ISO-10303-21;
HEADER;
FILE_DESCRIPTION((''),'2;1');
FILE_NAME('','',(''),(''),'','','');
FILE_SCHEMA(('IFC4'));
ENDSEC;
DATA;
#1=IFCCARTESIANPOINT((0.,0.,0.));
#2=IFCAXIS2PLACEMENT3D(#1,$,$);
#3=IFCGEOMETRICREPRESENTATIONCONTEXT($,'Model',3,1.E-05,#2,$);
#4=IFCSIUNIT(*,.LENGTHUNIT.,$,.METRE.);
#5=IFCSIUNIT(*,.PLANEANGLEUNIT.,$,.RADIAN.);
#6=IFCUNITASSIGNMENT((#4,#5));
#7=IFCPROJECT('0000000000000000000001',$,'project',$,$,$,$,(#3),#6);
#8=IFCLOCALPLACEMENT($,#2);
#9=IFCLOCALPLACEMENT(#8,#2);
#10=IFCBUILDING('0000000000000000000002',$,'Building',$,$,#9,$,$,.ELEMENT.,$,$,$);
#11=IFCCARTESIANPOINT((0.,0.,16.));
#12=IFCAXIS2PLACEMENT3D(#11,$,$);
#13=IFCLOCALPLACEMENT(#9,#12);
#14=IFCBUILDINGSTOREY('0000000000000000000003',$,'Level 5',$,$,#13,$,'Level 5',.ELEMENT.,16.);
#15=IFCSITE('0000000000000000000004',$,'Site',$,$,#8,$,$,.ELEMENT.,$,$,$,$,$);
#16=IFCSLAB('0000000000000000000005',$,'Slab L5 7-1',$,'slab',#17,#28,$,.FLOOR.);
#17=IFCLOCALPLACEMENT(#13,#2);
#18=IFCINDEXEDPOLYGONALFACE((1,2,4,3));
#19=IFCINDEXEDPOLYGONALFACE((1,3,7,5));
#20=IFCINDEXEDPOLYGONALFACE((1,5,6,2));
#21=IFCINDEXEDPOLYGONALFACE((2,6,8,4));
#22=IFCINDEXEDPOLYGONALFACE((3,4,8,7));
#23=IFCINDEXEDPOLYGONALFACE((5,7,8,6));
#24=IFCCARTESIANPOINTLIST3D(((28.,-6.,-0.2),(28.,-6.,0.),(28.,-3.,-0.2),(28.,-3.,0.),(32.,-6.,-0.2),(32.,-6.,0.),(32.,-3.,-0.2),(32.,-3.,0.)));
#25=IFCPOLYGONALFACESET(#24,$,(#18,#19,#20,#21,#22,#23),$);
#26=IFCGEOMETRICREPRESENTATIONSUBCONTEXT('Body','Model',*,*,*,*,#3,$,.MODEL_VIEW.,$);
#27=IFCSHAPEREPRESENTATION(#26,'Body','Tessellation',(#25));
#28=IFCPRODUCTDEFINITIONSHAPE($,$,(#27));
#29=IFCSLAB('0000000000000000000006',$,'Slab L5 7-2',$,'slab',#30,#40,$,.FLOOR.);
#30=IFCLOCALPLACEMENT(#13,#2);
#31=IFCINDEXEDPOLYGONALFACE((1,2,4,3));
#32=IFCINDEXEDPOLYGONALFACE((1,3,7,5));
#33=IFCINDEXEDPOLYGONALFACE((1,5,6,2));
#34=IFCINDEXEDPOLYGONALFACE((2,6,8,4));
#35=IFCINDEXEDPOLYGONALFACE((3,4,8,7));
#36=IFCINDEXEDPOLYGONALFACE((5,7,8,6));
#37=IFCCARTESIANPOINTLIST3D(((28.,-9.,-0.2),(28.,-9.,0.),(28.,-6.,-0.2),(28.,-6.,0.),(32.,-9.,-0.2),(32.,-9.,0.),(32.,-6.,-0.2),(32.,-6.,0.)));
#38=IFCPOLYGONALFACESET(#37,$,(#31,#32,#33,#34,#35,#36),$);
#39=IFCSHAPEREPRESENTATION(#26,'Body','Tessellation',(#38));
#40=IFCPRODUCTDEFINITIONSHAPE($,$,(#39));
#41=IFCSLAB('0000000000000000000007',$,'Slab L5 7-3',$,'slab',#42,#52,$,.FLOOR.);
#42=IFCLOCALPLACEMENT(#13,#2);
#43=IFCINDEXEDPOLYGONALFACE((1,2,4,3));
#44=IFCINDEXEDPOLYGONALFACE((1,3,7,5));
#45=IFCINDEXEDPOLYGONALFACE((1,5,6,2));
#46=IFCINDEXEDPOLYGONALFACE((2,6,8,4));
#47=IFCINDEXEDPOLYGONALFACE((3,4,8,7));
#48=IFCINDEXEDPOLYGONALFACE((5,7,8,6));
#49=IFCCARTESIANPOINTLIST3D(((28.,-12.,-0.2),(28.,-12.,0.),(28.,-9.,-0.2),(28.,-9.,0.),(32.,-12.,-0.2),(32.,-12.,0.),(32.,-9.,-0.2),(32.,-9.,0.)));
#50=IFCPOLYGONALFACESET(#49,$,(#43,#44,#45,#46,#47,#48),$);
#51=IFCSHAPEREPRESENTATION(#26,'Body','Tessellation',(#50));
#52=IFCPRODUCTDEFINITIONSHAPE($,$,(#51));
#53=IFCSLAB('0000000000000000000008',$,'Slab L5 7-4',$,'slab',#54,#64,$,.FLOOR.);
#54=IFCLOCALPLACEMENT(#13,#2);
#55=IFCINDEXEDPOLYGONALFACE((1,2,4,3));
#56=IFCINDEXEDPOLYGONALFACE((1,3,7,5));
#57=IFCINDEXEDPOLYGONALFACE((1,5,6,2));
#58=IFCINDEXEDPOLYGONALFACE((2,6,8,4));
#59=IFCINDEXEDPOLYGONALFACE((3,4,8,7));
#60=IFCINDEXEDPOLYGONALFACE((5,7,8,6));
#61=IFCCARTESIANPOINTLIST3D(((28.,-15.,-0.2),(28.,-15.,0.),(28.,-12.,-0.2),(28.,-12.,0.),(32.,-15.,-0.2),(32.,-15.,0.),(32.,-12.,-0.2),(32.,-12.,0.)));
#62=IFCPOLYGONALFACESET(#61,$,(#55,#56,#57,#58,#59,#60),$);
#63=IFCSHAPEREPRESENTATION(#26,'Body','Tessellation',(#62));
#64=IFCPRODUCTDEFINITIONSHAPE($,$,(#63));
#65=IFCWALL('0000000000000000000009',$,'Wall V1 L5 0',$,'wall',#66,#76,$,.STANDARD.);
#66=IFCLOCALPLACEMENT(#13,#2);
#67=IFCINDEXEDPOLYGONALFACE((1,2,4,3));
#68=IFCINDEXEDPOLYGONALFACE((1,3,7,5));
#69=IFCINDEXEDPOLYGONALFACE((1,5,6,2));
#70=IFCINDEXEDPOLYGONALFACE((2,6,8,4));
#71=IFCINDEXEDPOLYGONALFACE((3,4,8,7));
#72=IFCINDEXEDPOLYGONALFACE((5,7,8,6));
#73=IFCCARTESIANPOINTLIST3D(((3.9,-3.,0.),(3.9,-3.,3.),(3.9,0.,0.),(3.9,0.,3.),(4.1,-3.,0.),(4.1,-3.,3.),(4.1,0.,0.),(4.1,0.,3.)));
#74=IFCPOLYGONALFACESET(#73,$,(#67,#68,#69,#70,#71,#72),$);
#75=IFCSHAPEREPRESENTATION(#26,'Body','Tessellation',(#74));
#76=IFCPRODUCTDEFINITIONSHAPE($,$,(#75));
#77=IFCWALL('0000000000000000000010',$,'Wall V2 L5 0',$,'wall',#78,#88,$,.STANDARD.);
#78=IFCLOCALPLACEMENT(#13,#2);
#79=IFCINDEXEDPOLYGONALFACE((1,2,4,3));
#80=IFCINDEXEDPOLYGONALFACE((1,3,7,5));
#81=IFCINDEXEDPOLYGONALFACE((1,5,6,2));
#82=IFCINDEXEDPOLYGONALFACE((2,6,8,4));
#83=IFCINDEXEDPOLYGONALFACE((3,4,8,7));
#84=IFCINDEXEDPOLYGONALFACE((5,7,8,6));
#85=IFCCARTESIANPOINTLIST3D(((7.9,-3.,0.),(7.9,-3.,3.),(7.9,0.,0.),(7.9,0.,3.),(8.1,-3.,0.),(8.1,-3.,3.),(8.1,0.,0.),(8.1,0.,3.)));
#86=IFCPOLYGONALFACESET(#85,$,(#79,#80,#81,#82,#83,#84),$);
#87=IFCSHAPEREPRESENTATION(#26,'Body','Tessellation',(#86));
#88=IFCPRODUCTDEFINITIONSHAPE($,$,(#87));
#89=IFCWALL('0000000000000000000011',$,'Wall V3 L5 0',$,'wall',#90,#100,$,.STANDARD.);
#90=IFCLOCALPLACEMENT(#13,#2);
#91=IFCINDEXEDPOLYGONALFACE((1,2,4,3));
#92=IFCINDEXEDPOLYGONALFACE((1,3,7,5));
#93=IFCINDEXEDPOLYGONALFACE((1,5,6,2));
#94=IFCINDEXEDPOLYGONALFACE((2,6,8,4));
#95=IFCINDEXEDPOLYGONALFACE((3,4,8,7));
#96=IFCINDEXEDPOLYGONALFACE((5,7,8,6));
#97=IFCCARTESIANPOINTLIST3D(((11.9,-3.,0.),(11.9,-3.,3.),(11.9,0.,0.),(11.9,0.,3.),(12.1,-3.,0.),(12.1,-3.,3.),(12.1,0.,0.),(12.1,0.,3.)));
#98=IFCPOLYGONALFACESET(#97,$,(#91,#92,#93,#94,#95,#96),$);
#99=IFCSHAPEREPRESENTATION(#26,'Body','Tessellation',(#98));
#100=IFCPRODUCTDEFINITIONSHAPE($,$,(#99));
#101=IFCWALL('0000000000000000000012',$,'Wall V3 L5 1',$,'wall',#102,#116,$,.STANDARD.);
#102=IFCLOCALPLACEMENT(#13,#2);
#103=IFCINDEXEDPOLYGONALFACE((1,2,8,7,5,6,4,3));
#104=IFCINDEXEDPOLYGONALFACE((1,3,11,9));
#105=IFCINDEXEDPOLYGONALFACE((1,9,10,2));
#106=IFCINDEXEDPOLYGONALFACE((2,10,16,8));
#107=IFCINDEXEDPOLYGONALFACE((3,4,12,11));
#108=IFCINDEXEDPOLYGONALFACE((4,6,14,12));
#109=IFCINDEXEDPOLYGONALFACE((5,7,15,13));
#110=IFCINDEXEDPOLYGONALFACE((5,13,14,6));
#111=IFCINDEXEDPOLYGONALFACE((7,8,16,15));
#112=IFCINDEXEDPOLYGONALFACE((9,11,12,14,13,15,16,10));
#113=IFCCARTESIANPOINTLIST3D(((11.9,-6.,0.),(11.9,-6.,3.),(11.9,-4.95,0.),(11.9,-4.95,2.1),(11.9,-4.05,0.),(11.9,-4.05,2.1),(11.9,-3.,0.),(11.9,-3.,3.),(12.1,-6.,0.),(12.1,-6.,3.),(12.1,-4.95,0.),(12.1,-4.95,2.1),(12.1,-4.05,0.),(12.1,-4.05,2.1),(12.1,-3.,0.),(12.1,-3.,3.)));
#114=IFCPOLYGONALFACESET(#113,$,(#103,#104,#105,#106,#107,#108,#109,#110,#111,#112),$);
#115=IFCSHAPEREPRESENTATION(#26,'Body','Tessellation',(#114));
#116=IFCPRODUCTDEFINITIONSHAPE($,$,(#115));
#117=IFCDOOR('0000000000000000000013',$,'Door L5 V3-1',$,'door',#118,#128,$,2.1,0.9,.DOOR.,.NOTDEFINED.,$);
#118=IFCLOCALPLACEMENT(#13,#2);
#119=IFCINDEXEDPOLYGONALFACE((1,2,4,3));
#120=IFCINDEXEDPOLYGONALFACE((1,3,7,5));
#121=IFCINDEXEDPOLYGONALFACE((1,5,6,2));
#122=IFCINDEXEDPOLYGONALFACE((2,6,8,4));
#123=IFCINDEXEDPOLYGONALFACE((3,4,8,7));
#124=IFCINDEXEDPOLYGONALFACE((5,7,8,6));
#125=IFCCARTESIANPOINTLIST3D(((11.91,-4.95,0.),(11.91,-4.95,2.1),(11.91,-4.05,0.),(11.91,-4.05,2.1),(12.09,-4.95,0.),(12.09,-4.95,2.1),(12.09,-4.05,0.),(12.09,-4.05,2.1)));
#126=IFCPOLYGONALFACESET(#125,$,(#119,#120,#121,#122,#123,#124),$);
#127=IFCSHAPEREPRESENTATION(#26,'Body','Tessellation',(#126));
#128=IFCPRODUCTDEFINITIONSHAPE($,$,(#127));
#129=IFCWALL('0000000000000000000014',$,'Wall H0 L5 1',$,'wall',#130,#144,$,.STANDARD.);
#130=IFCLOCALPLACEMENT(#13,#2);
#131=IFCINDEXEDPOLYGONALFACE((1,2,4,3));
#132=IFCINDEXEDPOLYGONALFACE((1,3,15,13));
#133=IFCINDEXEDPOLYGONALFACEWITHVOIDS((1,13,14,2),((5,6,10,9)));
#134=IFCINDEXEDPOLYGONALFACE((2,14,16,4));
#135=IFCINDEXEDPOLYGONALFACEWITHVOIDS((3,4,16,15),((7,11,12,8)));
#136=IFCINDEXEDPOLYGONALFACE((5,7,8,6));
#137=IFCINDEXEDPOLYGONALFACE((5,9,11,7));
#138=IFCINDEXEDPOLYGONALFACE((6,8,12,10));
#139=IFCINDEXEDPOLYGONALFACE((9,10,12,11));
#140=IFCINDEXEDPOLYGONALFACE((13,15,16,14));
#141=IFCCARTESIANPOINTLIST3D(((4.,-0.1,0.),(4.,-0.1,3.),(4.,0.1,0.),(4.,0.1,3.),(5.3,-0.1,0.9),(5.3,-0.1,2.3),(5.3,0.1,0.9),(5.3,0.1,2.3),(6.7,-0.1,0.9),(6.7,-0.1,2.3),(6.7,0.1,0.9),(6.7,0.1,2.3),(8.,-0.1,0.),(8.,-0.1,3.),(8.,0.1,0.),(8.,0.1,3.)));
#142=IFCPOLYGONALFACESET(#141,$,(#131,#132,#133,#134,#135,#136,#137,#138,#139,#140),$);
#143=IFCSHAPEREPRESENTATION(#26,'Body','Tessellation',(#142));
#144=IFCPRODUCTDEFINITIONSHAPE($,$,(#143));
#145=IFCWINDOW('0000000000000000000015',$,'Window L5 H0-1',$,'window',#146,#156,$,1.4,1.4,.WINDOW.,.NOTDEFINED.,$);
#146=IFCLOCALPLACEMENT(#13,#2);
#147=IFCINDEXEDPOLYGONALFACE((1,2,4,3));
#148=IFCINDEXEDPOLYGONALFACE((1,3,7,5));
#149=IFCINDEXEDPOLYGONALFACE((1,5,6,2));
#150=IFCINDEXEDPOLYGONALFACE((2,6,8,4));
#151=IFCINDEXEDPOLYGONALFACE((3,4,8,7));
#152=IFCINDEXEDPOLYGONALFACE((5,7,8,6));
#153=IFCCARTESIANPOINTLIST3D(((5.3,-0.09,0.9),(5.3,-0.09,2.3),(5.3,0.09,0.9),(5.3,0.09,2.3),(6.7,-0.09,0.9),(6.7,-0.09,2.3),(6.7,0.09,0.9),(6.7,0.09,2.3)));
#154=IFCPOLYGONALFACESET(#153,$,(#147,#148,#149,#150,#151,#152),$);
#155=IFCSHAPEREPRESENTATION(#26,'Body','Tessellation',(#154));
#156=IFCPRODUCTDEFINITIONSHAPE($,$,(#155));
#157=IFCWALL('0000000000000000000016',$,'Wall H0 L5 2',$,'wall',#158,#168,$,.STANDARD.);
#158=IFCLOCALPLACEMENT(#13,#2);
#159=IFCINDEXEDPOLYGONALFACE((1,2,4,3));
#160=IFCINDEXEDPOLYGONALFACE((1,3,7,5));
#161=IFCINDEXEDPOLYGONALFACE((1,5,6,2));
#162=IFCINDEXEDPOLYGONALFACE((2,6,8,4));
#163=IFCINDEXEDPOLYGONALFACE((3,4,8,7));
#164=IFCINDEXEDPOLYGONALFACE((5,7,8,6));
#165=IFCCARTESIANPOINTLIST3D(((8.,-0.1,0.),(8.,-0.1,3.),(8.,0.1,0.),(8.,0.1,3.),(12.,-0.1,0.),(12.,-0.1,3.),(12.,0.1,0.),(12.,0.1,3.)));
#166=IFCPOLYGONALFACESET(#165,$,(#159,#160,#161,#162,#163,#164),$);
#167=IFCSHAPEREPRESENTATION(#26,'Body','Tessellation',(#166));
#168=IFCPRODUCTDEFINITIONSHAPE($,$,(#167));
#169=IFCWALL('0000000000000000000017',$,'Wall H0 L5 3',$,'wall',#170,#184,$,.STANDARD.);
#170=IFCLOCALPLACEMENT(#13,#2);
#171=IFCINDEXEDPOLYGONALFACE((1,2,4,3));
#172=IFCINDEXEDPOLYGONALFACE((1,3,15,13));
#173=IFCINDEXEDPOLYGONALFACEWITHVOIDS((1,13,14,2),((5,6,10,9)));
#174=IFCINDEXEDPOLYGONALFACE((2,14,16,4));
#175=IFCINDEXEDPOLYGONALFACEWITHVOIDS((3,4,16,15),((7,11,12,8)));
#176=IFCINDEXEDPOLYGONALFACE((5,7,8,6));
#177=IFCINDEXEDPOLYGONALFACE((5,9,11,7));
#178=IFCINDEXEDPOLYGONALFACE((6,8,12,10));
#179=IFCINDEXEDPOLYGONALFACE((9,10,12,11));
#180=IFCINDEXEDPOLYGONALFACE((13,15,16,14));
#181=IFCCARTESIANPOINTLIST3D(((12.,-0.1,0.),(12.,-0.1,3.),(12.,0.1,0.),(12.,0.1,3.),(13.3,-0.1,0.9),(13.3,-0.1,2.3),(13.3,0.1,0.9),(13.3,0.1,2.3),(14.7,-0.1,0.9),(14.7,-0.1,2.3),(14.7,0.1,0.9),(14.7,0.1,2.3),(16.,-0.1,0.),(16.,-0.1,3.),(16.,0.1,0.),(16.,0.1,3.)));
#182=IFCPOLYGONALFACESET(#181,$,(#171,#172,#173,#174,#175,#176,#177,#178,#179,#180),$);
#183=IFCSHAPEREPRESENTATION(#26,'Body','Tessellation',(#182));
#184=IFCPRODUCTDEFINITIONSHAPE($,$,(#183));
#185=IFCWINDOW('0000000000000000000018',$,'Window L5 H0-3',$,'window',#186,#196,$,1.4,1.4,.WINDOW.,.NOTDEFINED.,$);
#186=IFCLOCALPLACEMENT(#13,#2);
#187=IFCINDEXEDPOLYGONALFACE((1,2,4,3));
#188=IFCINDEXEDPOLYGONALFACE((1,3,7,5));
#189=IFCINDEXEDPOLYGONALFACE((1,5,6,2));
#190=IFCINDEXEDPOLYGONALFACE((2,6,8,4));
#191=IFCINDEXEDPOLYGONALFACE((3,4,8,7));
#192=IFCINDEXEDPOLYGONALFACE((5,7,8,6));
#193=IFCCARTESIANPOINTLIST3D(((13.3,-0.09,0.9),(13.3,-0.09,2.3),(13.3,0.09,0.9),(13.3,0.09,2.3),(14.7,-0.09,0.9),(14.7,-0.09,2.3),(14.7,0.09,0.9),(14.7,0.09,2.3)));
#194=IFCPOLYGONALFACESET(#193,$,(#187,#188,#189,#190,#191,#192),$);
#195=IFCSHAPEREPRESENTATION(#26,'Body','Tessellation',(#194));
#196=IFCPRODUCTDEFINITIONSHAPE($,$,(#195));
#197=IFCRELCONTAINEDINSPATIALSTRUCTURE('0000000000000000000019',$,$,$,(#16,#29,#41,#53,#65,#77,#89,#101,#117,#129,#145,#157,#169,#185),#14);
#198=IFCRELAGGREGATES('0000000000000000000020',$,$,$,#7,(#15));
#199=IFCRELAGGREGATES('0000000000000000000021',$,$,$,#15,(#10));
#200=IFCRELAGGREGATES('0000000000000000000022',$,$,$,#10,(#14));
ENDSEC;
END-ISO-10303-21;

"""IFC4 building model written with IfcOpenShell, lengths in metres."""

from ifc_helpers import new_model, si_unit, frame, frame_2d, origin, origin_2d, place, context, subcontext, project, spatial, polyline, rectangle, outline, extrude, element, fill, save


model = new_model("IFC4")

# Units and contexts
model_context = context("Model", 3, precision=1e-05, world=origin())
body_context = subcontext(model_context, "Body", "Model", "MODEL_VIEW")
ifc_project = project(units=[si_unit("LENGTHUNIT", "METRE"), si_unit("PLANEANGLEUNIT", "RADIAN")], contexts=[model_context])

# Site, building, storey
site_placement = place(None, origin())
site = spatial("IfcSite", under=ifc_project, at=site_placement, Name="Site", CompositionType="ELEMENT")
building_placement = place(site_placement, origin())
building = spatial("IfcBuilding", under=site, at=building_placement, Name="Building", CompositionType="ELEMENT")
storey_placement = place(building_placement, frame((0.0, 0.0, 16.0)))
storey = spatial("IfcBuildingStorey", under=building, at=storey_placement, Name="Level 5", LongName="Level 5", CompositionType="ELEMENT", Elevation=16.0)

# Slabs
slab_1_placement = place(storey_placement, frame((0.0, 0.0, -0.2)))
element("IfcSlab", 1, at=slab_1_placement, inside=storey, Name="Slab L5 7-1", ObjectType="slab", PredefinedType="FLOOR", context=body_context, shape_type="SweptSolid", body=[
    extrude(outline(polyline([(28.0, -6.0), (32.0, -6.0), (32.0, -3.0), (28.0, -3.0), (28.0, -6.0)])), origin(), (0.0, 0.0, 1.0), 0.2),
])
slab_2_placement = place(storey_placement, frame((0.0, 0.0, -0.2)))
element("IfcSlab", 2, at=slab_2_placement, inside=storey, Name="Slab L5 7-2", ObjectType="slab", PredefinedType="FLOOR", context=body_context, shape_type="SweptSolid", body=[
    extrude(outline(polyline([(28.0, -9.0), (32.0, -9.0), (32.0, -6.0), (28.0, -6.0), (28.0, -9.0)])), origin(), (0.0, 0.0, 1.0), 0.2),
])
slab_3_placement = place(storey_placement, frame((0.0, 0.0, -0.2)))
element("IfcSlab", 3, at=slab_3_placement, inside=storey, Name="Slab L5 7-3", ObjectType="slab", PredefinedType="FLOOR", context=body_context, shape_type="SweptSolid", body=[
    extrude(outline(polyline([(28.0, -12.0), (32.0, -12.0), (32.0, -9.0), (28.0, -9.0), (28.0, -12.0)])), origin(), (0.0, 0.0, 1.0), 0.2),
])
slab_4_placement = place(storey_placement, frame((0.0, 0.0, -0.2)))
element("IfcSlab", 4, at=slab_4_placement, inside=storey, Name="Slab L5 7-4", ObjectType="slab", PredefinedType="FLOOR", context=body_context, shape_type="SweptSolid", body=[
    extrude(outline(polyline([(28.0, -15.0), (32.0, -15.0), (32.0, -12.0), (28.0, -12.0), (28.0, -15.0)])), origin(), (0.0, 0.0, 1.0), 0.2),
])

# Walls
for number, where, z_axis, x_axis, name in (
    (5, (4.0, 0.0, 0.0), (0.0, 0.0, 1.0), (0.0, -1.0, 0.0), "Wall V1 L5 0"),
    (6, (8.0, 0.0, 0.0), (0.0, 0.0, 1.0), (0.0, -1.0, 0.0), "Wall V2 L5 0"),
    (7, (12.0, 0.0, 0.0), (0.0, 0.0, 1.0), (0.0, -1.0, 0.0), "Wall V3 L5 0"),
):
    element("IfcWall", number, at=place(storey_placement, frame(where, z_axis=z_axis, x_axis=x_axis)), inside=storey, Name=name, ObjectType="wall", PredefinedType="STANDARD", context=body_context, shape_type="SweptSolid", body=[
        extrude(rectangle(XDim=3.0, YDim=0.2, at=frame_2d((1.5, 0.0))), origin(), (0.0, 0.0, 1.0), 3.0),
    ])

# Wall, opening, door
wall_1_placement = place(storey_placement, frame((12.0, -3.0, 0.0), z_axis=(0.0, 0.0, 1.0), x_axis=(0.0, -1.0, 0.0)))
wall_1 = element("IfcWall", 8, at=wall_1_placement, inside=storey, Name="Wall V3 L5 1", ObjectType="wall", PredefinedType="STANDARD", context=body_context, shape_type="SweptSolid", body=[
    extrude(rectangle(XDim=3.0, YDim=0.2, at=frame_2d((1.5, 0.0))), origin(), (0.0, 0.0, 1.0), 3.0),
])
opening_1_placement = place(storey_placement, frame((12.0, -4.5, 0.0), z_axis=(0.0, 0.0, 1.0), x_axis=(0.0, -1.0, 0.0)))
opening_1 = element("IfcOpeningElement", 9, at=opening_1_placement, cuts=wall_1, ObjectType="Opening", PredefinedType="OPENING", context=body_context, shape_type="SweptSolid", body=[
    extrude(rectangle(XDim=0.9, YDim=0.22, at=origin_2d()), origin(), (0.0, 0.0, 1.0), 2.1),
])
door_placement = place(storey_placement, frame((12.0, -4.5, 0.0), z_axis=(0.0, 0.0, 1.0), x_axis=(0.0, -1.0, 0.0)))
door = element("IfcDoor", 10, at=door_placement, inside=storey, Name="Door L5 V3-1", ObjectType="door", OperationType="NOTDEFINED", OverallHeight=2.1, OverallWidth=0.9, PredefinedType="DOOR", context=body_context, shape_type="SweptSolid", body=[
    extrude(rectangle(XDim=0.9, YDim=0.18, at=origin_2d()), origin(), (0.0, 0.0, 1.0), 2.1),
])
fill(opening_1, door)

# Wall, opening, window
wall_2_placement = place(storey_placement, frame((4.0, 0.0, 0.0), z_axis=(0.0, 0.0, 1.0), x_axis=(1.0, 0.0, 0.0)))
wall_2 = element("IfcWall", 11, at=wall_2_placement, inside=storey, Name="Wall H0 L5 1", ObjectType="wall", PredefinedType="STANDARD", context=body_context, shape_type="SweptSolid", body=[
    extrude(rectangle(XDim=4.0, YDim=0.2, at=frame_2d((2.0, 0.0))), origin(), (0.0, 0.0, 1.0), 3.0),
])
opening_2_placement = place(storey_placement, frame((6.0, 0.0, 0.9), z_axis=(0.0, 0.0, 1.0), x_axis=(1.0, 0.0, 0.0)))
opening_2 = element("IfcOpeningElement", 12, at=opening_2_placement, cuts=wall_2, ObjectType="Opening", PredefinedType="OPENING", context=body_context, shape_type="SweptSolid", body=[
    extrude(rectangle(XDim=1.4, YDim=0.22, at=origin_2d()), origin(), (0.0, 0.0, 1.0), 1.4),
])
window_1_placement = place(storey_placement, frame((6.0, 0.0, 0.9), z_axis=(0.0, 0.0, 1.0), x_axis=(1.0, 0.0, 0.0)))
window_1 = element("IfcWindow", 13, at=window_1_placement, inside=storey, Name="Window L5 H0-1", ObjectType="window", OverallHeight=1.4, OverallWidth=1.4, PartitioningType="NOTDEFINED", PredefinedType="WINDOW", context=body_context, shape_type="SweptSolid", body=[
    extrude(rectangle(XDim=1.4, YDim=0.18, at=origin_2d()), origin(), (0.0, 0.0, 1.0), 1.4),
])
fill(opening_2, window_1)

# Wall
wall_3_placement = place(storey_placement, frame((8.0, 0.0, 0.0), z_axis=(0.0, 0.0, 1.0), x_axis=(1.0, 0.0, 0.0)))
element("IfcWall", 14, at=wall_3_placement, inside=storey, Name="Wall H0 L5 2", ObjectType="wall", PredefinedType="STANDARD", context=body_context, shape_type="SweptSolid", body=[
    extrude(rectangle(XDim=4.0, YDim=0.2, at=frame_2d((2.0, 0.0))), origin(), (0.0, 0.0, 1.0), 3.0),
])

# Wall, opening, window
wall_4_placement = place(storey_placement, frame((12.0, 0.0, 0.0), z_axis=(0.0, 0.0, 1.0), x_axis=(1.0, 0.0, 0.0)))
wall_4 = element("IfcWall", 15, at=wall_4_placement, inside=storey, Name="Wall H0 L5 3", ObjectType="wall", PredefinedType="STANDARD", context=body_context, shape_type="SweptSolid", body=[
    extrude(rectangle(XDim=4.0, YDim=0.2, at=frame_2d((2.0, 0.0))), origin(), (0.0, 0.0, 1.0), 3.0),
])
opening_3_placement = place(storey_placement, frame((14.0, 0.0, 0.9), z_axis=(0.0, 0.0, 1.0), x_axis=(1.0, 0.0, 0.0)))
opening_3 = element("IfcOpeningElement", 16, at=opening_3_placement, cuts=wall_4, ObjectType="Opening", PredefinedType="OPENING", context=body_context, shape_type="SweptSolid", body=[
    extrude(rectangle(XDim=1.4, YDim=0.22, at=origin_2d()), origin(), (0.0, 0.0, 1.0), 1.4),
])
window_2_placement = place(storey_placement, frame((14.0, 0.0, 0.9), z_axis=(0.0, 0.0, 1.0), x_axis=(1.0, 0.0, 0.0)))
window_2 = element("IfcWindow", 17, at=window_2_placement, inside=storey, Name="Window L5 H0-3", ObjectType="window", OverallHeight=1.4, OverallWidth=1.4, PartitioningType="NOTDEFINED", PredefinedType="WINDOW", context=body_context, shape_type="SweptSolid", body=[
    extrude(rectangle(XDim=1.4, YDim=0.18, at=origin_2d()), origin(), (0.0, 0.0, 1.0), 1.4),
])
fill(opening_3, window_2)

save(model, "model.ifc")
